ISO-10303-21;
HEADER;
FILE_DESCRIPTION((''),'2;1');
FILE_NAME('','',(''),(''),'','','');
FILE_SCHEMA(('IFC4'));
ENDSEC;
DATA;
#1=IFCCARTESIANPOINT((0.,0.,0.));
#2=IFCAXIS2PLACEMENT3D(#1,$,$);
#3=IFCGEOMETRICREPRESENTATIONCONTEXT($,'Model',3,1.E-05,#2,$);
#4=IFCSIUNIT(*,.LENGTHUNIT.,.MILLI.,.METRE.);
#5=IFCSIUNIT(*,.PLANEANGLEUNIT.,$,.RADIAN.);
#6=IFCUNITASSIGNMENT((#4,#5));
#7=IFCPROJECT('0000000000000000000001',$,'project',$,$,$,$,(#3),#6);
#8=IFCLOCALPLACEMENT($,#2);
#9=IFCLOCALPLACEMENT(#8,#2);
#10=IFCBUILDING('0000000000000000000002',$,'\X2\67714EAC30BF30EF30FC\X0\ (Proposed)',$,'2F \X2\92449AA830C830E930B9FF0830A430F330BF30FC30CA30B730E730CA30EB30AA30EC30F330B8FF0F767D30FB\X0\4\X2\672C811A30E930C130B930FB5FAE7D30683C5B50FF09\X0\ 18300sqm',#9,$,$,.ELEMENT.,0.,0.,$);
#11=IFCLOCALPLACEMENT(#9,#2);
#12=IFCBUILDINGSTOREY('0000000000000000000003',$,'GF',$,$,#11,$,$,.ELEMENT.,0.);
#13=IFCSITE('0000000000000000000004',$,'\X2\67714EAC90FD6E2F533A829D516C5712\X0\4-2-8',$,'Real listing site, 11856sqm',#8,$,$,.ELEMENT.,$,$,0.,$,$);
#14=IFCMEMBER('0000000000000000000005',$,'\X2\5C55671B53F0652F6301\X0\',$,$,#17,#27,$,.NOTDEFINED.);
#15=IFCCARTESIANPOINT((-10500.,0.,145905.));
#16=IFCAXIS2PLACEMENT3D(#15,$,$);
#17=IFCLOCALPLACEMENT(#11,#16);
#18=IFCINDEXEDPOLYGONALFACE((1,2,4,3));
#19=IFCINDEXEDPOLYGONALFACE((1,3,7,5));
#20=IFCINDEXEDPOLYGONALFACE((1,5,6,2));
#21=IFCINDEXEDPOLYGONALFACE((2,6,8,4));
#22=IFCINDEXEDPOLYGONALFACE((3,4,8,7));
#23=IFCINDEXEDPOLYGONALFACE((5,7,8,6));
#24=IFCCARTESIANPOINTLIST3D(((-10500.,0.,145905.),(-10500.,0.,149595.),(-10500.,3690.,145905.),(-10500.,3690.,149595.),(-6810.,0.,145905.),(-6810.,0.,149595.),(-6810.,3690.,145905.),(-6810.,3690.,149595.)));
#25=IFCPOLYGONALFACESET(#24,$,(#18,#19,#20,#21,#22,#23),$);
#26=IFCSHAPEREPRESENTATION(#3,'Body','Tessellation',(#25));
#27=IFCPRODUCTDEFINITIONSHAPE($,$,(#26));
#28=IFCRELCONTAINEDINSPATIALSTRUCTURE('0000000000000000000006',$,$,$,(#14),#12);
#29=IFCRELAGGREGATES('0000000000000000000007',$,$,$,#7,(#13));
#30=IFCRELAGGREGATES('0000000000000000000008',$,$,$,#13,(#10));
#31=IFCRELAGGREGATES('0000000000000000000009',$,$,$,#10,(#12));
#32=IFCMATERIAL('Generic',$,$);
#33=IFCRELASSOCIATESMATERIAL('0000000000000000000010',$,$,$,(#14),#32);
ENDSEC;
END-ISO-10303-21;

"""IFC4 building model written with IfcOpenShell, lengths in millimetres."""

from ifc_helpers import new_model, si_unit, frame, frame_2d, origin, place, context, project, spatial, rectangle, extrude, material, element, save


model = new_model("IFC4")

# Units and contexts
model_context = context("Model", 3, precision=1e-05, world=origin())
ifc_project = project(units=[si_unit("LENGTHUNIT", "METRE", prefix="MILLI"), si_unit("PLANEANGLEUNIT", "RADIAN")], contexts=[model_context])

# Site, building, storey
site_placement = place(None, origin())
site = spatial("IfcSite", under=ifc_project, at=site_placement, Name="東京都港区芝公園4-2-8", ObjectType="Real listing site, 11856sqm", CompositionType="ELEMENT", RefElevation=0.0)
building_placement = place(site_placement, origin())
building = spatial("IfcBuilding", under=site, at=building_placement, Name="東京タワー (Proposed)", ObjectType="2F 鉄骨トラス（インターナショナルオレンジ／白・4本脚ラチス・微細格子） 18300sqm", CompositionType="ELEMENT", ElevationOfRefHeight=0.0, ElevationOfTerrain=0.0)
storey_placement = place(building_placement, origin())
storey = spatial("IfcBuildingStorey", under=building, at=storey_placement, Name="GF", CompositionType="ELEMENT", Elevation=0.0)

# Shared definitions
ifc_material = material(Name="Generic")

# Member
member_1_placement = place(storey_placement, frame((-10500.0, 0.0, 145905.0)))
element("IfcMember", 1, at=member_1_placement, inside=storey, material=ifc_material, Name="展望台支持", PredefinedType="NOTDEFINED", context=model_context, shape_type="SweptSolid", body=[
    extrude(rectangle(XDim=3690.0, YDim=3690.0, at=frame_2d((1845.0, 1845.0))), frame((-10500.0, 0.0, 145905.0)), (0.0, 0.0, 1.0), 3690.0),
])

save(model, "model.ifc")
